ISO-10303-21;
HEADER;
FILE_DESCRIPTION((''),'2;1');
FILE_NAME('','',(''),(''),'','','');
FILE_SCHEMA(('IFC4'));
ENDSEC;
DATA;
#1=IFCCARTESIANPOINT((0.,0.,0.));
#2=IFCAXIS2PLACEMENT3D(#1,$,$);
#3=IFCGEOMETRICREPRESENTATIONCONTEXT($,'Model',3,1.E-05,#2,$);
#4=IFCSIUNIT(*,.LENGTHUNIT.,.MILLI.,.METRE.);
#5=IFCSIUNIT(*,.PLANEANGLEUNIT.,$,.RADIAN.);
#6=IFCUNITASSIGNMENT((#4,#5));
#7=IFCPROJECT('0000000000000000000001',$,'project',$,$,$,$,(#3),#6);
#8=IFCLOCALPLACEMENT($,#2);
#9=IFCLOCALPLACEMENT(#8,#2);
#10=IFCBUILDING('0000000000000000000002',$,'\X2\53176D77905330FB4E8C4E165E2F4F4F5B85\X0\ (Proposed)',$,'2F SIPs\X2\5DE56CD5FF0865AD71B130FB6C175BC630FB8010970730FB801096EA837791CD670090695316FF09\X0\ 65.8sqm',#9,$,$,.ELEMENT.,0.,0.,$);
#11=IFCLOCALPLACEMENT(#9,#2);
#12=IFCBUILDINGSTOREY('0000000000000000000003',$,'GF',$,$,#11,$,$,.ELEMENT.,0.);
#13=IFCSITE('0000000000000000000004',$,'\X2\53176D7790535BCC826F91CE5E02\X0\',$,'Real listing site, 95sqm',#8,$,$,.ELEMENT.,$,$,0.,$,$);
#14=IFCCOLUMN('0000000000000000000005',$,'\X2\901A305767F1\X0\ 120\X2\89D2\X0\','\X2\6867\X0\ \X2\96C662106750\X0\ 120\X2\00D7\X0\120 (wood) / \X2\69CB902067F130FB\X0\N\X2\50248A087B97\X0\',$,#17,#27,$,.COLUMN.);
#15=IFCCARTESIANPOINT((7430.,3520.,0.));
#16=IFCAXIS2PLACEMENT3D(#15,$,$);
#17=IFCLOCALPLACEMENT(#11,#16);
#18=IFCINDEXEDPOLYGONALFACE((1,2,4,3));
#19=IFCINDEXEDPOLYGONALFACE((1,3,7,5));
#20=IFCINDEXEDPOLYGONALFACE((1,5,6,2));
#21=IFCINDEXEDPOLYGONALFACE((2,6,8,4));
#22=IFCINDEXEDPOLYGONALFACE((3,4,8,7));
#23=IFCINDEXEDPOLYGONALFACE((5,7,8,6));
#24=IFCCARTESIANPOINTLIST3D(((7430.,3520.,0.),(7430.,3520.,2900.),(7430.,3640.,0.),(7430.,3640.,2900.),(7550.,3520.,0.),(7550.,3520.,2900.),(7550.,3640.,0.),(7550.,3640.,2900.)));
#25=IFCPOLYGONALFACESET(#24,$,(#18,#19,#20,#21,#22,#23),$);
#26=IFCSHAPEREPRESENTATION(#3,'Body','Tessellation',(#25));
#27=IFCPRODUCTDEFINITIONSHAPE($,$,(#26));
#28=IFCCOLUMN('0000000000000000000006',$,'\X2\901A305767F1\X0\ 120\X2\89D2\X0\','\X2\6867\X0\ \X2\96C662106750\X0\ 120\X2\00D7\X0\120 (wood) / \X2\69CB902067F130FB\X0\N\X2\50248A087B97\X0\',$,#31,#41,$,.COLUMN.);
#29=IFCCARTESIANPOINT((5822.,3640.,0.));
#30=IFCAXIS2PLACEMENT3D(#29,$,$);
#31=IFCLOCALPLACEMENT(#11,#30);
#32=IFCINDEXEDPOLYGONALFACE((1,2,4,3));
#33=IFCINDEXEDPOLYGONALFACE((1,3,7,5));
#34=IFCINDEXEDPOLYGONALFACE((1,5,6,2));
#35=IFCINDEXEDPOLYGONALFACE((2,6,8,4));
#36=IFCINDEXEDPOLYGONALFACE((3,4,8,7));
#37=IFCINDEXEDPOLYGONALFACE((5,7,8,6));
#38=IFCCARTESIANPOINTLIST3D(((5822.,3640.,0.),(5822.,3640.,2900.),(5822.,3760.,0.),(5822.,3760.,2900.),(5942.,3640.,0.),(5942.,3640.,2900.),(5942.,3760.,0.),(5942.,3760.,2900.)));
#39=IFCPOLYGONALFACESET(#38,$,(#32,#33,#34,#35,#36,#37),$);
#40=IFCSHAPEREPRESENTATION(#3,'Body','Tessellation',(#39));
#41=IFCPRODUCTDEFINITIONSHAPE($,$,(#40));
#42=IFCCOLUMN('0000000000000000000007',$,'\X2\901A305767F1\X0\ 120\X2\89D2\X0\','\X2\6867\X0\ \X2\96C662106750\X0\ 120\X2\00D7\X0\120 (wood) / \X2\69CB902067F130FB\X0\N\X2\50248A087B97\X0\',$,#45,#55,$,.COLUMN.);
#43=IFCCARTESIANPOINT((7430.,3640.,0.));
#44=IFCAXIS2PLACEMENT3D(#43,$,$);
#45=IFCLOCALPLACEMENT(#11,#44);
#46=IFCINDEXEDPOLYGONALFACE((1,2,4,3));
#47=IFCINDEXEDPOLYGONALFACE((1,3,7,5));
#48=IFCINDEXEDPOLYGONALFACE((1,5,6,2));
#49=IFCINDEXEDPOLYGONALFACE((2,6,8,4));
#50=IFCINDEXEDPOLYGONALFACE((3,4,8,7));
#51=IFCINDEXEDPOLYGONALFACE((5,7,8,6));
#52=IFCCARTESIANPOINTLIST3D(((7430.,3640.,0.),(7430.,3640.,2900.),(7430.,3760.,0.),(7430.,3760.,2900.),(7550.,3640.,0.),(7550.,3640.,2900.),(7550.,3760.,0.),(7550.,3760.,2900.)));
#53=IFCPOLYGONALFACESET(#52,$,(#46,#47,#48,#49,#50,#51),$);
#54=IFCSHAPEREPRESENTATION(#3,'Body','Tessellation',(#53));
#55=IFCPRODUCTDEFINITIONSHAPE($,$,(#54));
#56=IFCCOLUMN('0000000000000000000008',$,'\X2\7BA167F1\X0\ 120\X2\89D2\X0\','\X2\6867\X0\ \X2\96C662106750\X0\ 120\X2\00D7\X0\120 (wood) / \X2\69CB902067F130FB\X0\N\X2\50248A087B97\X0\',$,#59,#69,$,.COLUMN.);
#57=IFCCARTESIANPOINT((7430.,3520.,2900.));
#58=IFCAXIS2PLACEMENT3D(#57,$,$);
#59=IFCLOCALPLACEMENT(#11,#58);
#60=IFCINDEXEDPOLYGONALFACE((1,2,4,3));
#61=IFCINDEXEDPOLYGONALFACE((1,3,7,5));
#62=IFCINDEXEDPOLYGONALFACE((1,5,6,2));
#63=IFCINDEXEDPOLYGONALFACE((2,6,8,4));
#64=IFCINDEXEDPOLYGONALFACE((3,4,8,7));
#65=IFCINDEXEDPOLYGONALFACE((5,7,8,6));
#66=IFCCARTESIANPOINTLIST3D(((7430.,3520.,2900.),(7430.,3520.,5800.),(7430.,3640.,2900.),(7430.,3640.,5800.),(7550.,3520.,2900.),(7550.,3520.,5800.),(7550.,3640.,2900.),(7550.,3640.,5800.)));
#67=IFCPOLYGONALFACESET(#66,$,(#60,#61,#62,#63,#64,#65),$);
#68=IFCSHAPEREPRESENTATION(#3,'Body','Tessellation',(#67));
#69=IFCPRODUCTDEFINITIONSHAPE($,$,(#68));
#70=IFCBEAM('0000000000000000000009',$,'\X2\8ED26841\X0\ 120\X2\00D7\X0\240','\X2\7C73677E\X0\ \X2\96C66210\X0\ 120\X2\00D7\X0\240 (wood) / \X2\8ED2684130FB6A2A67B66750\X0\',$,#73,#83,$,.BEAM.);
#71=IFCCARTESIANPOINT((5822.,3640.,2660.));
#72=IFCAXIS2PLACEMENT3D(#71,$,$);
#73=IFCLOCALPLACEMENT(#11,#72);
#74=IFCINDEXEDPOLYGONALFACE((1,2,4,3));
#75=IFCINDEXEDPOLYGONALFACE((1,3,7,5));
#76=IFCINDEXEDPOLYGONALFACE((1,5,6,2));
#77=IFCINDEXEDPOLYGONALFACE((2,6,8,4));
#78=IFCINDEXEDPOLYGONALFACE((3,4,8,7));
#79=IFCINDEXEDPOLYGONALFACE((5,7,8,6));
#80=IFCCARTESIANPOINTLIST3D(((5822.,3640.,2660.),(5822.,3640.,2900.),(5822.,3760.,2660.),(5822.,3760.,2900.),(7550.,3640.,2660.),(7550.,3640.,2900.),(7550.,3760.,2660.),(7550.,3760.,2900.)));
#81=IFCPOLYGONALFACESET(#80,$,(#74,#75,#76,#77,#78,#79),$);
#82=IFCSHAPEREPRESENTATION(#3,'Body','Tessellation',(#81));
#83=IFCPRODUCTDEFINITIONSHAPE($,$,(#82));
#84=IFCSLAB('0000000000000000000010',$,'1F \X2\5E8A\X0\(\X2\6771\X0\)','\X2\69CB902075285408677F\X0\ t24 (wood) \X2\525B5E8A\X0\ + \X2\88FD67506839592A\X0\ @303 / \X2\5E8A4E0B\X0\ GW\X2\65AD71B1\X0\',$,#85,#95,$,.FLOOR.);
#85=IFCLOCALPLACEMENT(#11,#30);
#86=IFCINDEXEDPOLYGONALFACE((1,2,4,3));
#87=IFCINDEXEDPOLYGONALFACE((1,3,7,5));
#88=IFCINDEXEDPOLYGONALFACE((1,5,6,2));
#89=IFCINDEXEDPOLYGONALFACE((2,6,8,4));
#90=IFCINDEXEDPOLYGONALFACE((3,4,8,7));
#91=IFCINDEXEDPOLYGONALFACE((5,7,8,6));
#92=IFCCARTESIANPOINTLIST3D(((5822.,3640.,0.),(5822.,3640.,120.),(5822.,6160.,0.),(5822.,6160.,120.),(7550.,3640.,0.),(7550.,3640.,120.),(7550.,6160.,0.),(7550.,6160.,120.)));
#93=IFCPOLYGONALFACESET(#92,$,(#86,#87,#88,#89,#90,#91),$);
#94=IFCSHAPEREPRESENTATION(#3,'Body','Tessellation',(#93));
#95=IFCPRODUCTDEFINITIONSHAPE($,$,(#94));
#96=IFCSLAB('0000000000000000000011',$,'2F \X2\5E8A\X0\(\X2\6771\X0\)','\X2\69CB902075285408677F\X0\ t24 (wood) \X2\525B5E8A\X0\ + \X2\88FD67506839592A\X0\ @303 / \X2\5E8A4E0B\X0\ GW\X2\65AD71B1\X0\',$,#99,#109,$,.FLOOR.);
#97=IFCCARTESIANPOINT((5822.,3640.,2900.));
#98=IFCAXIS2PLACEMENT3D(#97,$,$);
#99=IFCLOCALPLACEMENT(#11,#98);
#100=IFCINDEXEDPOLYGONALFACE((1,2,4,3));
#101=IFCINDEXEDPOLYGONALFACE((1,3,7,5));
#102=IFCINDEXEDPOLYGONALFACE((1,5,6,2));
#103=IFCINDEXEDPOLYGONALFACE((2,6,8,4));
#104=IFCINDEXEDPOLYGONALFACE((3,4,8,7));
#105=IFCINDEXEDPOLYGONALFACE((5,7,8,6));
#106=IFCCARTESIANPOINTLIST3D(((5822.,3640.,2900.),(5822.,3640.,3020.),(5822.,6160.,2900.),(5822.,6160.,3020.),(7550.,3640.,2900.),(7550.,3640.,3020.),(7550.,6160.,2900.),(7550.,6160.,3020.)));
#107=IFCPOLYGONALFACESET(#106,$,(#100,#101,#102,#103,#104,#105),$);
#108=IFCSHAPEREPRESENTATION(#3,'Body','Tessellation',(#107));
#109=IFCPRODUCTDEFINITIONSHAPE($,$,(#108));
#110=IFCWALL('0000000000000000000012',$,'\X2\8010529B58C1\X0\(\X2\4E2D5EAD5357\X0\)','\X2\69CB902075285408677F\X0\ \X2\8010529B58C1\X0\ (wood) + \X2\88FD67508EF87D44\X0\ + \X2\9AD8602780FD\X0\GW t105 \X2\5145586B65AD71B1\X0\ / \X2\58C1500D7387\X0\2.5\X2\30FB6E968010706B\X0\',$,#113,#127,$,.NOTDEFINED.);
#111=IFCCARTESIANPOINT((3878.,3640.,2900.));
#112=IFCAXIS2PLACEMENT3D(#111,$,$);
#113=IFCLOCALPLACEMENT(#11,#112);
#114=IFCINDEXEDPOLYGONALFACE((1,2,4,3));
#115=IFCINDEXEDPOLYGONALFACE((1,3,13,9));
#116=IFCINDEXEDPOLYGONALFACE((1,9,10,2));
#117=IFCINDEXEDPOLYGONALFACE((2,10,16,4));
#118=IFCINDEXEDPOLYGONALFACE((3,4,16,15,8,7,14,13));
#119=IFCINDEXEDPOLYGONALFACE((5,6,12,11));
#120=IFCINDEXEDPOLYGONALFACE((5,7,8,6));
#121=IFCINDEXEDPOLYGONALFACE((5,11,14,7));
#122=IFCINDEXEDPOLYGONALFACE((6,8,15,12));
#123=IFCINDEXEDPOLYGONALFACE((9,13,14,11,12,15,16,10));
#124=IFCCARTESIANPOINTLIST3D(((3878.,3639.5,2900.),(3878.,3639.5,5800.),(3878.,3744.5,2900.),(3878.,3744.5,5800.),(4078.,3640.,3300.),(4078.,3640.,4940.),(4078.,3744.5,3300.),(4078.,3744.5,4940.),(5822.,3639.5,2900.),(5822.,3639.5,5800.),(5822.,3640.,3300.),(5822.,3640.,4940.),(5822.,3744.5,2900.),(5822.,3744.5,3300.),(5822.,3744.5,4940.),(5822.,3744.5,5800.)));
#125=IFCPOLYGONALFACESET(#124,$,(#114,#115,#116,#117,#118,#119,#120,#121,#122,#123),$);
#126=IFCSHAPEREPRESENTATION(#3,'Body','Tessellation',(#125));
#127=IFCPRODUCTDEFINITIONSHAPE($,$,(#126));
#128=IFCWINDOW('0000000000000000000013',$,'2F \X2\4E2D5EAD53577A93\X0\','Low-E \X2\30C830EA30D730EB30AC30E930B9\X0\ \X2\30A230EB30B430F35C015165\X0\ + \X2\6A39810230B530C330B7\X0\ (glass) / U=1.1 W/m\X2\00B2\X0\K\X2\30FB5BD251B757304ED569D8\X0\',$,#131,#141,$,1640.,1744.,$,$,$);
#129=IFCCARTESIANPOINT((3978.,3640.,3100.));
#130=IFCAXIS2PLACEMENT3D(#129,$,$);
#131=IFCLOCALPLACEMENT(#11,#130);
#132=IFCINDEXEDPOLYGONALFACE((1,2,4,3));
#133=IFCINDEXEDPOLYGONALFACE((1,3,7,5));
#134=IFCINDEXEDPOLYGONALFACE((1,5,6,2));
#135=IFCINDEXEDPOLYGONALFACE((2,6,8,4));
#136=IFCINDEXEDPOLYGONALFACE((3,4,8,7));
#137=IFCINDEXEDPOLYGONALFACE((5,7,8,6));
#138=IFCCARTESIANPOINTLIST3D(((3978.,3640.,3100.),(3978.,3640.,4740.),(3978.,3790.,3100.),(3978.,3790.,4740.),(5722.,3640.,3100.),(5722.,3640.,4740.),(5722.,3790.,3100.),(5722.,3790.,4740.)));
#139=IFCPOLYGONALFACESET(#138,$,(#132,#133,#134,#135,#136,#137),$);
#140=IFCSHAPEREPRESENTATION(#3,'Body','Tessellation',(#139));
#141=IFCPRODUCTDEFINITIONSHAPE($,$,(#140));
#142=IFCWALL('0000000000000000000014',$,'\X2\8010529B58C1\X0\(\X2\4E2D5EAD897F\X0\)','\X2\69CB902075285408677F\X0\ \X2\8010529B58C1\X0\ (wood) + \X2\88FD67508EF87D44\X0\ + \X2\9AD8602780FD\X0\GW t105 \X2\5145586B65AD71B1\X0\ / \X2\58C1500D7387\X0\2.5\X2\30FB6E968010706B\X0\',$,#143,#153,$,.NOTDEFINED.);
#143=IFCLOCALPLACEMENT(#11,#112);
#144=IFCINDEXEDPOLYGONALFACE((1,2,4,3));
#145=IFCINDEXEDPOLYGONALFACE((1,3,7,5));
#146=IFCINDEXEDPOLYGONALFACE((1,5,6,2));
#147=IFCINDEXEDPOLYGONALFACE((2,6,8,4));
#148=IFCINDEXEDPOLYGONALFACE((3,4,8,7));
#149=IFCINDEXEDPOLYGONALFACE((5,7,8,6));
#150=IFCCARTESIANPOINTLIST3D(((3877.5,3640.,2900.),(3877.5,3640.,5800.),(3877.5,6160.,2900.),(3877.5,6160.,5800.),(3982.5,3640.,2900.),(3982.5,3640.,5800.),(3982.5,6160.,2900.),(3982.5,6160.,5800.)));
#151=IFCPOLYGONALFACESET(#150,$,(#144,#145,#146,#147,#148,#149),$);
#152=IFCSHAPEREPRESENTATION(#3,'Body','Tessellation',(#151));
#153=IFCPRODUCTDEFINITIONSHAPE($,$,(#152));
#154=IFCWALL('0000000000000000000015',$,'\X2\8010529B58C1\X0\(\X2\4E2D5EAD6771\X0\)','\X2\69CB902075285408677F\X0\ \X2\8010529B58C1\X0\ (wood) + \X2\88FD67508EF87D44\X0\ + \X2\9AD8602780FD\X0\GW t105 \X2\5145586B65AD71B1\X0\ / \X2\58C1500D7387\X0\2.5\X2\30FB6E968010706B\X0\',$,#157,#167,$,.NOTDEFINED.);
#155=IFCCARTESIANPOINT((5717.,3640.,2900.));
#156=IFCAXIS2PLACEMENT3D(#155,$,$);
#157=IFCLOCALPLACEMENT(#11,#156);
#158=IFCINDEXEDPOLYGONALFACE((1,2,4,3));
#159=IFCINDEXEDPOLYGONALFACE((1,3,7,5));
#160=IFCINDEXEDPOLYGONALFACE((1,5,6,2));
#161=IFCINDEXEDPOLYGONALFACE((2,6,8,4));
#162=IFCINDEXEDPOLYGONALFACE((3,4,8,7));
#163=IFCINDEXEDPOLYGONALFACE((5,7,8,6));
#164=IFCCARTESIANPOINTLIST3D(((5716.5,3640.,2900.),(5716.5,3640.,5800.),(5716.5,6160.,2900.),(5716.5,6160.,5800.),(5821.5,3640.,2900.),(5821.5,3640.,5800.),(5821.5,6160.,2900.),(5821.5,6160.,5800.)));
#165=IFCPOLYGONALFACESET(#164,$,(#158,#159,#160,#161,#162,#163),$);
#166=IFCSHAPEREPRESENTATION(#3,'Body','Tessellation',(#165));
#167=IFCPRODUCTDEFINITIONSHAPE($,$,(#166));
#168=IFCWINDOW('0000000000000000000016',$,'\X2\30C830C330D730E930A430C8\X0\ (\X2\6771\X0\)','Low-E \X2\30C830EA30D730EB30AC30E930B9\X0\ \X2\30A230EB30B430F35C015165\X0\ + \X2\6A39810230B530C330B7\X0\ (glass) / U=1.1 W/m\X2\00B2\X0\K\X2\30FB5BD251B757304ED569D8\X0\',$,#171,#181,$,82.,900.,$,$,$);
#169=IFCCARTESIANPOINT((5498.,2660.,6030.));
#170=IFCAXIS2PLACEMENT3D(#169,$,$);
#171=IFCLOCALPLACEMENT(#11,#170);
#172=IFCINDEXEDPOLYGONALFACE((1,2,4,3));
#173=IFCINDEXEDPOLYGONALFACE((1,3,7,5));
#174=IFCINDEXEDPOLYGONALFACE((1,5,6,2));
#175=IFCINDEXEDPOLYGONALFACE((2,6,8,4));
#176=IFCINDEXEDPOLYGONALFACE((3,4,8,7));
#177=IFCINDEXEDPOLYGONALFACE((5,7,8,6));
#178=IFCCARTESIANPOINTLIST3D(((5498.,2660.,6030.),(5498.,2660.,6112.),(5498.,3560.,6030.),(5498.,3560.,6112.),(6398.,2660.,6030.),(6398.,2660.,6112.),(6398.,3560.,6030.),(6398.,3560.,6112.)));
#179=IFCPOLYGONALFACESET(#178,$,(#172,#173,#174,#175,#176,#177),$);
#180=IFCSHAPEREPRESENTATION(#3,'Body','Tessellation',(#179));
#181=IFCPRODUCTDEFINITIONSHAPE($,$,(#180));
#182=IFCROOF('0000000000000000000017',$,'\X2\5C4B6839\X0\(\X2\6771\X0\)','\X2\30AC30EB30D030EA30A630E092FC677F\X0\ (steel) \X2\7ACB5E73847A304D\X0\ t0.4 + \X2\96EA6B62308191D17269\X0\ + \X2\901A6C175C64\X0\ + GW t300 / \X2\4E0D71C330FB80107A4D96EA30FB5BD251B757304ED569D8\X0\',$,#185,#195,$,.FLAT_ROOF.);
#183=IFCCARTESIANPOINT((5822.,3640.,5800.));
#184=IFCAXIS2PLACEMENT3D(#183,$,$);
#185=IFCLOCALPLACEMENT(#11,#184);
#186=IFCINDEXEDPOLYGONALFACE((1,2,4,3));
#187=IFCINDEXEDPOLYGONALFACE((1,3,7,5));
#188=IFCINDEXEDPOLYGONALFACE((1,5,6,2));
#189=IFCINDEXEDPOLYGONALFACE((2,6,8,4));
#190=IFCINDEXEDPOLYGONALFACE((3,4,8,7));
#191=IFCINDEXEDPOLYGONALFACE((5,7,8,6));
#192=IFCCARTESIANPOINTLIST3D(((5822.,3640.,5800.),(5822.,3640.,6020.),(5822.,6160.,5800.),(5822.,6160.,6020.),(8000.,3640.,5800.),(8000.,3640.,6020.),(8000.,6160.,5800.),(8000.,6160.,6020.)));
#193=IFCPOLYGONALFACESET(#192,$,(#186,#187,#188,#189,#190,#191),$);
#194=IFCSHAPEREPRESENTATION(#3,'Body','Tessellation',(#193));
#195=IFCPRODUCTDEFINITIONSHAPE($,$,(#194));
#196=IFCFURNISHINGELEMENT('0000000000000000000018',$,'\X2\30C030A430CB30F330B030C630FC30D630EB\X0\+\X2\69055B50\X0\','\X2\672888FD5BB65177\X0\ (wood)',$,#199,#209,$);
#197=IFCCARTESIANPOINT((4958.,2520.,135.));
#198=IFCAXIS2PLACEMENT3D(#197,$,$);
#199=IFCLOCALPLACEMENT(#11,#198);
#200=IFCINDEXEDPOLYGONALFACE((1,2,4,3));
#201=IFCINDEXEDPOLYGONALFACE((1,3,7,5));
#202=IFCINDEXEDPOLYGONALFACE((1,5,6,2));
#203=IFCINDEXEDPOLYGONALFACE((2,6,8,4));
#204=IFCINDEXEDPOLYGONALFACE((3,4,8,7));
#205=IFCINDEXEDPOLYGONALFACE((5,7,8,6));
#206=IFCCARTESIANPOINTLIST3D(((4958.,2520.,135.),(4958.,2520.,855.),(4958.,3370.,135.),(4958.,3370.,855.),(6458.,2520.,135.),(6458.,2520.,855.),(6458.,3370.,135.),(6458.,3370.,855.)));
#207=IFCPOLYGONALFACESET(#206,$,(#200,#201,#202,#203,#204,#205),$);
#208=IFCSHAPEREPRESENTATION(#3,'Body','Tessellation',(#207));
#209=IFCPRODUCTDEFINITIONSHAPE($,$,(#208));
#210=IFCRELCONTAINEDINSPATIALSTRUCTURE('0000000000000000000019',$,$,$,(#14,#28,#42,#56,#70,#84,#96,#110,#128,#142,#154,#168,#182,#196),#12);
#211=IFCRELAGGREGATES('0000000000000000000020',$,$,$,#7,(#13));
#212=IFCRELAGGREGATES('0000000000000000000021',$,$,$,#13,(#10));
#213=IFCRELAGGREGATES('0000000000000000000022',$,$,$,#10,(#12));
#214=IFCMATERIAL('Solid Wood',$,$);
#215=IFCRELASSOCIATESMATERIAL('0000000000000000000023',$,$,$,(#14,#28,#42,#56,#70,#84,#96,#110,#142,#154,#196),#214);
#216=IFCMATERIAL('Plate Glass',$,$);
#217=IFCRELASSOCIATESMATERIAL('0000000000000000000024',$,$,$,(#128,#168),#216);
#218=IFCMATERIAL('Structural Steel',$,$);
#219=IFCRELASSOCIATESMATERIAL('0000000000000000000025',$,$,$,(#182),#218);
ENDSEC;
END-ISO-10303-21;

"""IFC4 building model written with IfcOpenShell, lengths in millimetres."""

from ifc_helpers import new_model, si_unit, frame, frame_2d, origin, place, context, project, spatial, rectangle, extrude, material, element, fill, save


model = new_model("IFC4")

# Units and contexts
model_context = context("Model", 3, precision=1e-05, world=origin())
ifc_project = project(units=[si_unit("LENGTHUNIT", "METRE", prefix="MILLI"), si_unit("PLANEANGLEUNIT", "RADIAN")], contexts=[model_context])

# Site, building, storey
site_placement = place(None, origin())
site = spatial("IfcSite", under=ifc_project, at=site_placement, Name="北海道富良野市", ObjectType="Real listing site, 95sqm", CompositionType="ELEMENT", RefElevation=0.0)
building_placement = place(site_placement, origin())
building = spatial("IfcBuilding", under=site, at=building_placement, Name="北海道・二世帯住宅 (Proposed)", ObjectType="2F SIPs工法（断熱・気密・耐震・耐雪荷重最適化） 65.8sqm", CompositionType="ELEMENT", ElevationOfRefHeight=0.0, ElevationOfTerrain=0.0)
storey_placement = place(building_placement, origin())
storey = spatial("IfcBuildingStorey", under=building, at=storey_placement, Name="GF", CompositionType="ELEMENT", Elevation=0.0)

# Columns
ifc_material_1 = material(Name="Solid Wood")
column_1_placement = place(storey_placement, frame((7430.0, 3520.0, 0.0)))
element("IfcColumn", 1, at=column_1_placement, inside=storey, material=ifc_material_1, Name="通し柱 120角", Description="桧 集成材 120×120 (wood) / 構造柱・N値計算", PredefinedType="COLUMN", context=model_context, shape_type="SweptSolid", body=[
    extrude(rectangle(XDim=120.0, YDim=120.0, at=frame_2d((60.0, 60.0))), frame((7430.0, 3520.0, 0.0)), (0.0, 0.0, 1.0), 2900.0),
])
column_2_placement = place(storey_placement, frame((5822.0, 3640.0, 0.0)))
element("IfcColumn", 2, at=column_2_placement, inside=storey, material=ifc_material_1, Name="通し柱 120角", Description="桧 集成材 120×120 (wood) / 構造柱・N値計算", PredefinedType="COLUMN", context=model_context, shape_type="SweptSolid", body=[
    extrude(rectangle(XDim=120.0, YDim=120.0, at=frame_2d((60.0, 60.0))), frame((5822.0, 3640.0, 0.0)), (0.0, 0.0, 1.0), 2900.0),
])
column_3_placement = place(storey_placement, frame((7430.0, 3640.0, 0.0)))
element("IfcColumn", 3, at=column_3_placement, inside=storey, material=ifc_material_1, Name="通し柱 120角", Description="桧 集成材 120×120 (wood) / 構造柱・N値計算", PredefinedType="COLUMN", context=model_context, shape_type="SweptSolid", body=[
    extrude(rectangle(XDim=120.0, YDim=120.0, at=frame_2d((60.0, 60.0))), frame((7430.0, 3640.0, 0.0)), (0.0, 0.0, 1.0), 2900.0),
])
column_4_placement = place(storey_placement, frame((7430.0, 3520.0, 2900.0)))
element("IfcColumn", 4, at=column_4_placement, inside=storey, material=ifc_material_1, Name="管柱 120角", Description="桧 集成材 120×120 (wood) / 構造柱・N値計算", PredefinedType="COLUMN", context=model_context, shape_type="SweptSolid", body=[
    extrude(rectangle(XDim=120.0, YDim=120.0, at=frame_2d((60.0, 60.0))), frame((7430.0, 3520.0, 2900.0)), (0.0, 0.0, 1.0), 2900.0),
])

# Beam
beam_1_placement = place(storey_placement, frame((5822.0, 3640.0, 2660.0)))
element("IfcBeam", 5, at=beam_1_placement, inside=storey, material=ifc_material_1, Name="軒桁 120×240", Description="米松 集成 120×240 (wood) / 軒桁・横架材", PredefinedType="BEAM", context=model_context, shape_type="SweptSolid", body=[
    extrude(rectangle(XDim=1728.0, YDim=120.0, at=frame_2d((864.0, 60.0))), frame((5822.0, 3640.0, 2660.0)), (0.0, 0.0, 1.0), 240.0),
])

# Slabs
slab_1_placement = place(storey_placement, frame((5822.0, 3640.0, 0.0)))
element("IfcSlab", 6, at=slab_1_placement, inside=storey, material=ifc_material_1, Name="1F 床(東)", Description="構造用合板 t24 (wood) 剛床 + 製材根太 @303 / 床下 GW断熱", PredefinedType="FLOOR", context=model_context, shape_type="SweptSolid", body=[
    extrude(rectangle(XDim=1728.0, YDim=2520.0, at=frame_2d((864.0, 1260.0))), frame((5822.0, 3640.0, 0.0)), (0.0, 0.0, 1.0), 120.0),
])
slab_2_placement = place(storey_placement, frame((5822.0, 3640.0, 2900.0)))
element("IfcSlab", 7, at=slab_2_placement, inside=storey, material=ifc_material_1, Name="2F 床(東)", Description="構造用合板 t24 (wood) 剛床 + 製材根太 @303 / 床下 GW断熱", PredefinedType="FLOOR", context=model_context, shape_type="SweptSolid", body=[
    extrude(rectangle(XDim=1728.0, YDim=2520.0, at=frame_2d((864.0, 1260.0))), frame((5822.0, 3640.0, 2900.0)), (0.0, 0.0, 1.0), 120.0),
])

# Wall, opening, window
wall_1_placement = place(storey_placement, frame((3878.0, 3640.0, 2900.0)))
wall_1 = element("IfcWall", 8, at=wall_1_placement, inside=storey, material=ifc_material_1, Name="耐力壁(中庭南)", Description="構造用合板 耐力壁 (wood) + 製材軸組 + 高性能GW t105 充填断熱 / 壁倍率2.5・準耐火", PredefinedType="NOTDEFINED", context=model_context, shape_type="SweptSolid", body=[
    extrude(rectangle(XDim=1944.0, YDim=105.0, at=frame_2d((972.0, 52.0))), frame((3878.0, 3640.0, 2900.0)), (0.0, 0.0, 1.0), 2900.0),
])
opening_placement = place(storey_placement, frame((3978.0, 3640.0, 3100.0)))
opening = element("IfcOpeningElement", 9, at=opening_placement, cuts=wall_1, PredefinedType="NOTDEFINED", context=model_context, shape_type="SweptSolid", body=[
    extrude(rectangle(XDim=1744.0, YDim=150.0, at=frame_2d((872.0, 75.0))), frame((3978.0, 3640.0, 3100.0)), (0.0, 0.0, 1.0), 1640.0),
])
ifc_material_2 = material(Name="Plate Glass")
window_1_placement = place(storey_placement, frame((3978.0, 3640.0, 3100.0)))
window_1 = element("IfcWindow", 10, at=window_1_placement, inside=storey, material=ifc_material_2, Name="2F 中庭南窓", Description="Low-E トリプルガラス アルゴン封入 + 樹脂サッシ (glass) / U=1.1 W/m²K・寒冷地仕様", OverallHeight=1640.0, OverallWidth=1744.0, context=model_context, shape_type="SweptSolid", body=[
    extrude(rectangle(XDim=1744.0, YDim=150.0, at=frame_2d((872.0, 75.0))), frame((3978.0, 3640.0, 3100.0)), (0.0, 0.0, 1.0), 1640.0),
])
fill(opening, window_1)

# Walls
wall_2_placement = place(storey_placement, frame((3878.0, 3640.0, 2900.0)))
element("IfcWall", 11, at=wall_2_placement, inside=storey, material=ifc_material_1, Name="耐力壁(中庭西)", Description="構造用合板 耐力壁 (wood) + 製材軸組 + 高性能GW t105 充填断熱 / 壁倍率2.5・準耐火", PredefinedType="NOTDEFINED", context=model_context, shape_type="SweptSolid", body=[
    extrude(rectangle(XDim=105.0, YDim=2520.0, at=frame_2d((52.0, 1260.0))), frame((3878.0, 3640.0, 2900.0)), (0.0, 0.0, 1.0), 2900.0),
])
wall_3_placement = place(storey_placement, frame((5717.0, 3640.0, 2900.0)))
element("IfcWall", 12, at=wall_3_placement, inside=storey, material=ifc_material_1, Name="耐力壁(中庭東)", Description="構造用合板 耐力壁 (wood) + 製材軸組 + 高性能GW t105 充填断熱 / 壁倍率2.5・準耐火", PredefinedType="NOTDEFINED", context=model_context, shape_type="SweptSolid", body=[
    extrude(rectangle(XDim=105.0, YDim=2520.0, at=frame_2d((52.0, 1260.0))), frame((5717.0, 3640.0, 2900.0)), (0.0, 0.0, 1.0), 2900.0),
])

# Window
window_2_placement = place(storey_placement, frame((5498.0, 2660.0, 6030.0)))
element("IfcWindow", 13, at=window_2_placement, inside=storey, material=ifc_material_2, Name="トップライト (東)", Description="Low-E トリプルガラス アルゴン封入 + 樹脂サッシ (glass) / U=1.1 W/m²K・寒冷地仕様", OverallHeight=82.0, OverallWidth=900.0, context=model_context, shape_type="SweptSolid", body=[
    extrude(rectangle(XDim=900.0, YDim=900.0, at=frame_2d((450.0, 450.0))), frame((5498.0, 2660.0, 6030.0)), (0.0, 0.0, 1.0), 82.0),
])

# Roof
ifc_material_3 = material(Name="Structural Steel")
for number, where, name in (
    (14, (5822.0, 3640.0, 5800.0), "屋根(東)"),
):
    element("IfcRoof", number, at=place(storey_placement, frame(where)), inside=storey, material=ifc_material_3, Name=name, Description="ガルバリウム鋼板 (steel) 立平葺き t0.4 + 雪止め金物 + 通気層 + GW t300 / 不燃・耐積雪・寒冷地仕様", PredefinedType="FLAT_ROOF", context=model_context, shape_type="SweptSolid", body=[
        extrude(rectangle(XDim=2178.0, YDim=2520.0, at=frame_2d((1089.0, 1260.0))), frame((5822.0, 3640.0, 5800.0)), (0.0, 0.0, 1.0), 220.0),
    ])

# Furnishing element
furnishing_1_placement = place(storey_placement, frame((4958.0, 2520.0, 135.0)))
element("IfcFurnishingElement", 15, at=furnishing_1_placement, inside=storey, material=ifc_material_1, Name="ダイニングテーブル+椅子", Description="木製家具 (wood)", context=model_context, shape_type="SweptSolid", body=[
    extrude(rectangle(XDim=1500.0, YDim=850.0, at=frame_2d((750.0, 425.0))), frame((4958.0, 2520.0, 135.0)), (0.0, 0.0, 1.0), 720.0),
])

save(model, "model.ifc")
